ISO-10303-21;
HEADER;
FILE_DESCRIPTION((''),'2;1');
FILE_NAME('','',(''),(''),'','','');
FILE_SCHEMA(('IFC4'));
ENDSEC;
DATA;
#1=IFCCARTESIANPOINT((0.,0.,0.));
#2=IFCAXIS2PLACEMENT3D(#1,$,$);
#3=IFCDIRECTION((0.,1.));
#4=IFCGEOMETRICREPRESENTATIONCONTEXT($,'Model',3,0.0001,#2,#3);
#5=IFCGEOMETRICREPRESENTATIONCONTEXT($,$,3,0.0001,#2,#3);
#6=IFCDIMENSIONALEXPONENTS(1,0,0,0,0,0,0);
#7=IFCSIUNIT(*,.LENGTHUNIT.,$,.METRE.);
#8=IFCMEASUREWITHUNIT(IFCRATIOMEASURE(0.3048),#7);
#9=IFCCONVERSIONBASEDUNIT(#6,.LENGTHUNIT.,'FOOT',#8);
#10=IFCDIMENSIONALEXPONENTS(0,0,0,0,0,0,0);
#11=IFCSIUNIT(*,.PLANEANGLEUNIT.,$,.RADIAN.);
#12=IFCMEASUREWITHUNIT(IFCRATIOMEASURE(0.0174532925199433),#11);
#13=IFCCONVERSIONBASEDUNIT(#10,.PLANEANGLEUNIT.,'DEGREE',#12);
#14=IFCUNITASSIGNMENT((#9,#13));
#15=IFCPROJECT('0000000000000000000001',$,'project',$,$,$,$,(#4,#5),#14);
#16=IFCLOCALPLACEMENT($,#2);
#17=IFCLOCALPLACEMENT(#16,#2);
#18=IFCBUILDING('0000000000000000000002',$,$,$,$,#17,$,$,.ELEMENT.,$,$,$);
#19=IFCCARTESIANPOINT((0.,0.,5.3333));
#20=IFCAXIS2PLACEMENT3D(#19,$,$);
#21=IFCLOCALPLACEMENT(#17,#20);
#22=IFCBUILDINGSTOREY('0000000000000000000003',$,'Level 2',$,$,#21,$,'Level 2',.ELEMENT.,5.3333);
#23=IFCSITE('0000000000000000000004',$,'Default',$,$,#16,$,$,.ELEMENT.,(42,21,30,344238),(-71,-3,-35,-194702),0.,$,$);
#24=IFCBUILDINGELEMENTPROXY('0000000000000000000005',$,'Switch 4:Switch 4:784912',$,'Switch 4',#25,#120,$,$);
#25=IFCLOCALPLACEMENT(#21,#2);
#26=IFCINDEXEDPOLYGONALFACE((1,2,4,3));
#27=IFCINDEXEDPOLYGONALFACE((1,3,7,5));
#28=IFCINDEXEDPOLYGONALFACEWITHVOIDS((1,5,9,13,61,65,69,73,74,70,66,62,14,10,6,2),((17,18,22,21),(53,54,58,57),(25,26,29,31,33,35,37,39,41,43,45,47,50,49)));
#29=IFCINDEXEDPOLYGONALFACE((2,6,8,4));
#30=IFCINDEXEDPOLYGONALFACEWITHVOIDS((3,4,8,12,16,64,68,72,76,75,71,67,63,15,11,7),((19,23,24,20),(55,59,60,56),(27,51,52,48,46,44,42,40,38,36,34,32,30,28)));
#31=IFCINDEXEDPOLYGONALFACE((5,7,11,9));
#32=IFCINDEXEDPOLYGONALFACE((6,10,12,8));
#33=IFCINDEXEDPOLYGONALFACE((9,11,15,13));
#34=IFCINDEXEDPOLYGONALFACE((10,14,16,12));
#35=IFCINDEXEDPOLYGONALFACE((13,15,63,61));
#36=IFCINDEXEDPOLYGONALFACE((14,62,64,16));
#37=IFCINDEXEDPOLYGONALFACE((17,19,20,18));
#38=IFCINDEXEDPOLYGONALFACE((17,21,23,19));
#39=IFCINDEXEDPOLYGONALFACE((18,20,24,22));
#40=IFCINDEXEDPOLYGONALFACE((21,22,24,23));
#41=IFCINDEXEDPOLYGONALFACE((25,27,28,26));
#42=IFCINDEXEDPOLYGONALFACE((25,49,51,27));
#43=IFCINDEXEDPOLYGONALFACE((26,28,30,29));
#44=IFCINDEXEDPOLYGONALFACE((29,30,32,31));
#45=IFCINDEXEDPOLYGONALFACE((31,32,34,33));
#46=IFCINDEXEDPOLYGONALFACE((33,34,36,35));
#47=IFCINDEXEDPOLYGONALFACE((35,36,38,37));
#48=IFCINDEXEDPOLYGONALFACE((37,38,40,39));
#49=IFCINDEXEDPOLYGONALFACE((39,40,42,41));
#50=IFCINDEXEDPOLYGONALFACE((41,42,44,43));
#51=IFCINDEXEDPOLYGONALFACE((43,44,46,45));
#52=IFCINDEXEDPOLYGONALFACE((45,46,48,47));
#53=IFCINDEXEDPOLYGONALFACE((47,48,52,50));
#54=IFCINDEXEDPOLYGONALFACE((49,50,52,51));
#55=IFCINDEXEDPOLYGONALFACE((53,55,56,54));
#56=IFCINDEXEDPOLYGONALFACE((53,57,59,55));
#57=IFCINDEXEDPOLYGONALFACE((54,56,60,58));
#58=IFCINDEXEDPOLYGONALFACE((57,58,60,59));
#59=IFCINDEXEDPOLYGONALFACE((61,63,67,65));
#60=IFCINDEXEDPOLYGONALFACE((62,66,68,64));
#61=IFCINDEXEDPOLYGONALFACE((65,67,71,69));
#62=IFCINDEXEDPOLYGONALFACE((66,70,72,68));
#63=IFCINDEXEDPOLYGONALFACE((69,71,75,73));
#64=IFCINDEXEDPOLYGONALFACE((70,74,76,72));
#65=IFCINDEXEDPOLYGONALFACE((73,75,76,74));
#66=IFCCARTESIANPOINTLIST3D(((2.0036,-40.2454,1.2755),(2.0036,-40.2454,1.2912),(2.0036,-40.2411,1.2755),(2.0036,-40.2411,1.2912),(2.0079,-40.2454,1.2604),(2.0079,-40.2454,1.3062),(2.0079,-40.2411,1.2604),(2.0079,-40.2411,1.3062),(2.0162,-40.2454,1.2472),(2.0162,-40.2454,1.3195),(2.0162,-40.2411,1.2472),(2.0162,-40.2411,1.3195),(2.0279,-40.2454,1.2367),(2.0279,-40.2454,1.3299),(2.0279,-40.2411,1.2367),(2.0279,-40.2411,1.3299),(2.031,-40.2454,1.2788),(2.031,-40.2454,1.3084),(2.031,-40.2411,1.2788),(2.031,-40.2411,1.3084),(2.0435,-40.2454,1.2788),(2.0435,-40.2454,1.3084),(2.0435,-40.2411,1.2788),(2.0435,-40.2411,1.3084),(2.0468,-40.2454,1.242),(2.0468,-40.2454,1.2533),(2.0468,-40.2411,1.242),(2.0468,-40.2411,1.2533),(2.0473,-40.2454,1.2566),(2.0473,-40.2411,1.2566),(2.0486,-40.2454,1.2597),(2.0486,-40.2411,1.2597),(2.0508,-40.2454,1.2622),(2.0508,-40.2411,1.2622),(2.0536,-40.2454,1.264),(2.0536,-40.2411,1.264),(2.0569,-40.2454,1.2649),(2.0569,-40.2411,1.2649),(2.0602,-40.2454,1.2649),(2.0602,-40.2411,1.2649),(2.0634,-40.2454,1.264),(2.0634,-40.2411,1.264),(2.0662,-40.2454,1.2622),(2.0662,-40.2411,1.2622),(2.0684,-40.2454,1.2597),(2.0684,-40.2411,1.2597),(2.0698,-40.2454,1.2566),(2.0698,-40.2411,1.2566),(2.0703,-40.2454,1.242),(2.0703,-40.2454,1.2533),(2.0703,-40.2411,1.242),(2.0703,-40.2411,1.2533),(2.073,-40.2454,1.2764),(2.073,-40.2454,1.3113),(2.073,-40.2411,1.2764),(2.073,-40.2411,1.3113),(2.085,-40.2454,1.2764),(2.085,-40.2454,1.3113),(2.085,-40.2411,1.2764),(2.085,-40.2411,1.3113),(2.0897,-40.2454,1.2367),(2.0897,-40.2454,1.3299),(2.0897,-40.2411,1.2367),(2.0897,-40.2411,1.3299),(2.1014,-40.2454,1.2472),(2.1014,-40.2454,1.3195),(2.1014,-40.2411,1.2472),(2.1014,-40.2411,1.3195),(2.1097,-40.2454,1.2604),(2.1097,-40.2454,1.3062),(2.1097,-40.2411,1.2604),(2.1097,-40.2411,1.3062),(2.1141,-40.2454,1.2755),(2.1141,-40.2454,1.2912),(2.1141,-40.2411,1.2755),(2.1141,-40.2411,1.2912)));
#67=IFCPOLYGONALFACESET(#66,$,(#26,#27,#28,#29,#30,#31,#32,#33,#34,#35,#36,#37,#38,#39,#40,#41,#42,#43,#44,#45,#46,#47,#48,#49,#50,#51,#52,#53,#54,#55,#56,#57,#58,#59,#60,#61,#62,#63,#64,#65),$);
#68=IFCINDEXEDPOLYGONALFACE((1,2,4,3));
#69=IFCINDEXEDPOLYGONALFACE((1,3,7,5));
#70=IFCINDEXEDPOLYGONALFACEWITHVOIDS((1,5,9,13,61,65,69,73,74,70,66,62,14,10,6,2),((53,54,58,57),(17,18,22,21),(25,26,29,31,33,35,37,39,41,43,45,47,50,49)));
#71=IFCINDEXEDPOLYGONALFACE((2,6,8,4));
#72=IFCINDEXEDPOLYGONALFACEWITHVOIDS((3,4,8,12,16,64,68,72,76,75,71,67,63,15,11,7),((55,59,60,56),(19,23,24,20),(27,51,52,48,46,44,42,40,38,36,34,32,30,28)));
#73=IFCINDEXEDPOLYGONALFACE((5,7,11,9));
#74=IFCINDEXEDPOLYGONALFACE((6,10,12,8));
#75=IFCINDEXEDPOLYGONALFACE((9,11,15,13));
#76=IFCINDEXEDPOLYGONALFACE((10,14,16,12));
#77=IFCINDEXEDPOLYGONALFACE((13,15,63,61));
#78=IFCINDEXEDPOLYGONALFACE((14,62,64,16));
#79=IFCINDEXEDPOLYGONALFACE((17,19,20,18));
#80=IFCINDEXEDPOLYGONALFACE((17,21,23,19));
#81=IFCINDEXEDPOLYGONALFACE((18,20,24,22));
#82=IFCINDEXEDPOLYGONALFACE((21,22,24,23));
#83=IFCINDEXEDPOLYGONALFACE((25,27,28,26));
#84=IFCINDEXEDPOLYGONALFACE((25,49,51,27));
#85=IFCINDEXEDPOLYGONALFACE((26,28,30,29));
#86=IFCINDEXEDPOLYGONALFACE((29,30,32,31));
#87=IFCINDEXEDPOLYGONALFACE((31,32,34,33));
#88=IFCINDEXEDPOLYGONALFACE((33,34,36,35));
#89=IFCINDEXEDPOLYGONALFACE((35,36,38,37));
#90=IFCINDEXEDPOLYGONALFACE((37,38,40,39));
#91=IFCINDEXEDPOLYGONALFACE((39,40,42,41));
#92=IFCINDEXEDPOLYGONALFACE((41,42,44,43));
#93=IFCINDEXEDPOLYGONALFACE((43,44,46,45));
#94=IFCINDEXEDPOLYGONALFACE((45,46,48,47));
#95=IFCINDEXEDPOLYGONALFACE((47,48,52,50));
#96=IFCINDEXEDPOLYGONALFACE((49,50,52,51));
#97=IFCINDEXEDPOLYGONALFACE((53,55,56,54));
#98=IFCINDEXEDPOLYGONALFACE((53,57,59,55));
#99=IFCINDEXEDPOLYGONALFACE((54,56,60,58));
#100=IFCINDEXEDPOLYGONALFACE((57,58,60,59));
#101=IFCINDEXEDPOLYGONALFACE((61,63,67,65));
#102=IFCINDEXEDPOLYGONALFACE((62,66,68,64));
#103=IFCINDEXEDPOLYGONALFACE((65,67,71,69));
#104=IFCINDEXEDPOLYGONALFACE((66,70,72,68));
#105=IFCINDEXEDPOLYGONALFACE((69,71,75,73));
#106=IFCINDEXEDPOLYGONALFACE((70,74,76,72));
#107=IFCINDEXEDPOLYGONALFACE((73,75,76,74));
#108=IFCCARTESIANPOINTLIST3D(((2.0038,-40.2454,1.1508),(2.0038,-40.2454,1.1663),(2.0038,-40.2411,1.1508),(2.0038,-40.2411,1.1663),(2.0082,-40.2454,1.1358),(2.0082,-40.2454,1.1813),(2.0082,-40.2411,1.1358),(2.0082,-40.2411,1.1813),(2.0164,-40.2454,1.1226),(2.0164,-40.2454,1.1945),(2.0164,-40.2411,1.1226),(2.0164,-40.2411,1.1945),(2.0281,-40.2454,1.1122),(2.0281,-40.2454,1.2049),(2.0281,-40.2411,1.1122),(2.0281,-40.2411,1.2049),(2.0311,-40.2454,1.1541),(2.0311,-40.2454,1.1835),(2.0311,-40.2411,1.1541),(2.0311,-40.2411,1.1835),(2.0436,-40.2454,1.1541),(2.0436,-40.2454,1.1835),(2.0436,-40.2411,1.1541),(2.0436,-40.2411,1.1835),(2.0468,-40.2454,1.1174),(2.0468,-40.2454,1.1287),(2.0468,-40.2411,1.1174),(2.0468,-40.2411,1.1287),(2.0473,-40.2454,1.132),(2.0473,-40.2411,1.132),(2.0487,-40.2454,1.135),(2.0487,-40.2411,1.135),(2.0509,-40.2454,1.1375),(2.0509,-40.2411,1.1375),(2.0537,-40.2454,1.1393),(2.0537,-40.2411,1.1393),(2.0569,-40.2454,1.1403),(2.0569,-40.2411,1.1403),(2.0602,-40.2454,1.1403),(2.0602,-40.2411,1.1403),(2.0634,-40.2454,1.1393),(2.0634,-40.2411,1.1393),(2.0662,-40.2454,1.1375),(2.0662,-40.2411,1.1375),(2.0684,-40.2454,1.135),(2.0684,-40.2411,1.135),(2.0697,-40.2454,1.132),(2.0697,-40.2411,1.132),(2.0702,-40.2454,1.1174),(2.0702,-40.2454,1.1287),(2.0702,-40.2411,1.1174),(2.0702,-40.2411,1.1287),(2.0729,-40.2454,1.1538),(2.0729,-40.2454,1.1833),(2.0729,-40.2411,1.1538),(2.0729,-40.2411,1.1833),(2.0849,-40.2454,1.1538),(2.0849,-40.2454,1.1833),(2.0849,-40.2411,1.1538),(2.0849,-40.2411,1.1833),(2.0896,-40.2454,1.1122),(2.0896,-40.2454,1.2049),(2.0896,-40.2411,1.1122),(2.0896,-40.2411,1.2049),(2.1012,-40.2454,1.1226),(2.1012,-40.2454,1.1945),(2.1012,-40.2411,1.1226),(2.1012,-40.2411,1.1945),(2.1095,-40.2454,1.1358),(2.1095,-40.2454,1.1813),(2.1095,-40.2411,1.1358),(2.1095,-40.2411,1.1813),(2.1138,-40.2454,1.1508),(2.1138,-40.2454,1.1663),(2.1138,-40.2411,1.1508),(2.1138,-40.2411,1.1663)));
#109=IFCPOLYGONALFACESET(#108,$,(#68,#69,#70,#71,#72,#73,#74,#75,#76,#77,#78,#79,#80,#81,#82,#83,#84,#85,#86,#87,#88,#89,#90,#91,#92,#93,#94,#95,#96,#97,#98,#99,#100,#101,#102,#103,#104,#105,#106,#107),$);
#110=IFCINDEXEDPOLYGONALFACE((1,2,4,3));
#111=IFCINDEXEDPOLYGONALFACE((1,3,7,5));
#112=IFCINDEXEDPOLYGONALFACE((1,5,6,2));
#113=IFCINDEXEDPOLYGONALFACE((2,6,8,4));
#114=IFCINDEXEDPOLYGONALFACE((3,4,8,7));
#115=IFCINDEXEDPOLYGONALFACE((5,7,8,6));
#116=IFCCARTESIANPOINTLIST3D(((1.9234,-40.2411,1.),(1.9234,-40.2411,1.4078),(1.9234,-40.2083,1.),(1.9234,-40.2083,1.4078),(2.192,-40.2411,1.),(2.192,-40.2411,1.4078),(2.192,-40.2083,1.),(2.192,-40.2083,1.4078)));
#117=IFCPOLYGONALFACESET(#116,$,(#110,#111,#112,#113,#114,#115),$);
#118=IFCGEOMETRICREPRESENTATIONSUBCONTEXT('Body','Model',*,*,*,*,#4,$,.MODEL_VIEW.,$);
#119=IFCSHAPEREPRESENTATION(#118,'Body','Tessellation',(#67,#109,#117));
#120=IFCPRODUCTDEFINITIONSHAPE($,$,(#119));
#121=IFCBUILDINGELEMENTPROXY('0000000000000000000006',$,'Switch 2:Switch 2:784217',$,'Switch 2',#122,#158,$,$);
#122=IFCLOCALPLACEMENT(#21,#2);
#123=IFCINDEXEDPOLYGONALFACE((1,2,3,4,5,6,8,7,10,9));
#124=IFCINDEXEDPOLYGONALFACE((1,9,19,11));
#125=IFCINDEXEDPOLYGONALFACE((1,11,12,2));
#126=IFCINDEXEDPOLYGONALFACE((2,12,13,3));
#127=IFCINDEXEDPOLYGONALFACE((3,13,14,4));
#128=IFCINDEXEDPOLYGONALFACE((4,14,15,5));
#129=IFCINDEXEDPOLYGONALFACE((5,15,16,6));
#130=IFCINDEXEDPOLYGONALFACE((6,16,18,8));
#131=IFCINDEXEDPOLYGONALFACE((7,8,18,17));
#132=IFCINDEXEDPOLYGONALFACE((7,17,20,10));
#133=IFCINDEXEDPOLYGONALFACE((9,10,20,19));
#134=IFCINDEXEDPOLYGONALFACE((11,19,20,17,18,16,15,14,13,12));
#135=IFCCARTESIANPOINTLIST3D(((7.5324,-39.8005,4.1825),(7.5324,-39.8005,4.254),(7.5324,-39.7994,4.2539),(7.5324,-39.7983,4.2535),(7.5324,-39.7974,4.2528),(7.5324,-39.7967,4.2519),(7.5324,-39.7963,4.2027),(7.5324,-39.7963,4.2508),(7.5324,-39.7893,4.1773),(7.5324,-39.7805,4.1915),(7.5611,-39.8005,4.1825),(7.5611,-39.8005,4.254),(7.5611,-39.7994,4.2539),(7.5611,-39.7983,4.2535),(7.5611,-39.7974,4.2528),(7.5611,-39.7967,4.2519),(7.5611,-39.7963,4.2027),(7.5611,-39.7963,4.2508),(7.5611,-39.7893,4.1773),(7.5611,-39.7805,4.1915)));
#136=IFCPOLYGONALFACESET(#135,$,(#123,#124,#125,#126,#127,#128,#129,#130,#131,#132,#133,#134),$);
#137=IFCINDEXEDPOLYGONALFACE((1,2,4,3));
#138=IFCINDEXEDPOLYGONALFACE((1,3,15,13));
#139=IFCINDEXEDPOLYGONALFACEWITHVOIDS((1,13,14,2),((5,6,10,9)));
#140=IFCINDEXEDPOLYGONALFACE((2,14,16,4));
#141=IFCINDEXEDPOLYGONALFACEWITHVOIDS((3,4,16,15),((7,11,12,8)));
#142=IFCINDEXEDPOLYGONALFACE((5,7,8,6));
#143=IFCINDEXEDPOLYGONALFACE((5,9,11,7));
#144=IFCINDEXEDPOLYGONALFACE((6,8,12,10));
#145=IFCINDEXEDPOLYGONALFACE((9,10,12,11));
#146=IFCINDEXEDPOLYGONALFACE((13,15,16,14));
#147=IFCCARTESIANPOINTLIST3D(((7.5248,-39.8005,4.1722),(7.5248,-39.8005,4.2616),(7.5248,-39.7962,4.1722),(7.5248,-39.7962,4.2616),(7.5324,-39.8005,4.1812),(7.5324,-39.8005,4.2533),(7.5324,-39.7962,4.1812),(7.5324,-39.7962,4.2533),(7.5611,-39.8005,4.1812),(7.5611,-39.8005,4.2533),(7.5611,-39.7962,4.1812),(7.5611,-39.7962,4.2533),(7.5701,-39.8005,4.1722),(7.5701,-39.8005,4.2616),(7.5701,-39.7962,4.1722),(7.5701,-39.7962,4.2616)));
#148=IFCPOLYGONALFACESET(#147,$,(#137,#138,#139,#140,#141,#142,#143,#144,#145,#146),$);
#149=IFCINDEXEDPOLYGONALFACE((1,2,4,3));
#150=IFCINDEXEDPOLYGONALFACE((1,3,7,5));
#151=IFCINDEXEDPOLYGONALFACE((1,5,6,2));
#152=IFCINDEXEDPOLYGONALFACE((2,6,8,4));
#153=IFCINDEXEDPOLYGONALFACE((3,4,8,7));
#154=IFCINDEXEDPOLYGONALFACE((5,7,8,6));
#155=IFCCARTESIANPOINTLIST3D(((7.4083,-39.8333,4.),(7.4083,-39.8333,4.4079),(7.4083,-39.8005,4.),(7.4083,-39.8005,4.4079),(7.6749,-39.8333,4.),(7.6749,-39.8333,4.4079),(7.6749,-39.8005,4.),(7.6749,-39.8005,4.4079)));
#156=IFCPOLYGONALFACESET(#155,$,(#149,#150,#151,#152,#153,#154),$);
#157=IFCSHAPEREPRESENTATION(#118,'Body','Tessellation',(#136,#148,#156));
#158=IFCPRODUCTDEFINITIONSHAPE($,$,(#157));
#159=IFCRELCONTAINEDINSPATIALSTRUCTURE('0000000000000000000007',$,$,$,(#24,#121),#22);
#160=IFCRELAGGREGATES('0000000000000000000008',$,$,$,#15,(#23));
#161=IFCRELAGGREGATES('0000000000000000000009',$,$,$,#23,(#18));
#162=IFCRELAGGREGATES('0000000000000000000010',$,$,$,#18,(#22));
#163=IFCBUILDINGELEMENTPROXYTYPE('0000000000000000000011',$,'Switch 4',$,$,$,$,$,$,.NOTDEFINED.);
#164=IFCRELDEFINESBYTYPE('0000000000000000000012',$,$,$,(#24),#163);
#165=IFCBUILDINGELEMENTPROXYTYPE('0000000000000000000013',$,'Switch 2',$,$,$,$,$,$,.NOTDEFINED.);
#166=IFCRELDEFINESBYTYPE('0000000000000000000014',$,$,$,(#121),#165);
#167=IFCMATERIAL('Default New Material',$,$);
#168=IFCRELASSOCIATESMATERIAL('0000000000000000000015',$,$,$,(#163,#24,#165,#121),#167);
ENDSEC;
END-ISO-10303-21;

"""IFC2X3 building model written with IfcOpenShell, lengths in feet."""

from ifc_helpers import new_model, entity, si_unit, converted_unit, direction, frame, frame_2d, origin, origin_2d_with_axis, place, context, subcontext, project, spatial, polyline, circle_curve, parameter, trimmed, segment, composite_curve, rectangle, outline, extrude, source, transform, mapped, material, type_object, type_shapes, element, save


model = new_model("IFC2X3")

# Units and contexts
model_context = context("Model", 3, precision=0.0001, world=origin(), true_north=direction((0.0, 1.0)))
context_of_model = context(None, 3, precision=0.0001, world=origin(), true_north=direction((0.0, 1.0)))
body_context = subcontext(model_context, "Body", "Model", "MODEL_VIEW")
ifc_project = project(units=[converted_unit("LENGTHUNIT", "FOOT", entity("IfcRatioMeasure", 0.3048), si_unit("LENGTHUNIT", "METRE"), dimensions=[1, 0, 0, 0, 0, 0, 0]), converted_unit("PLANEANGLEUNIT", "DEGREE", entity("IfcRatioMeasure", 0.0174532925199433), si_unit("PLANEANGLEUNIT", "RADIAN"), dimensions=[0, 0, 0, 0, 0, 0, 0])], contexts=[model_context, context_of_model])

# Site, building, storey
site_placement = place(None, origin())
site = spatial("IfcSite", under=ifc_project, at=site_placement, Name="Default", CompositionType="ELEMENT", RefLatitude=(42, 21, 30, 344238), RefLongitude=(-71, -3, -35, -194702), RefElevation=0.0)
building_placement = place(site_placement, origin())
building = spatial("IfcBuilding", under=site, at=building_placement, CompositionType="ELEMENT")
storey_placement = place(building_placement, frame((0.0, 0.0, 5.3333)))
storey = spatial("IfcBuildingStorey", under=building, at=storey_placement, Name="Level 2", LongName="Level 2", CompositionType="ELEMENT", Elevation=5.3333)

# Shared definitions
ifc_material = material(Name="Default New Material")

# Building element proxies
building_element_proxy_type_1 = type_object("IfcBuildingElementProxyType", Name="Switch 4", PredefinedType="NOTDEFINED", material=ifc_material)
shared_shape_1 = source(origin(), body_context, "Body", "SweptSolid", [
    extrude(outline(composite_curve([segment(polyline([(-0.0309, -0.0466), (0.0309, -0.0466)]), True, "CONTINUOUS"), segment(trimmed(circle_curve(frame_2d((-0.0003, 0.0), x_axis=(-1.0, 0.0)), 0.0561), [parameter(123.794741)], [parameter(236.205259)], True, "PARAMETER"), True, "CONTINUOUS"), segment(polyline([(0.0309, 0.0466), (-0.0309, 0.0466)]), True, "CONTINUOUS"), segment(trimmed(circle_curve(frame_2d((0.0003, 0.0), x_axis=(1.0, 0.0)), 0.0561), [parameter(123.794741)], [parameter(236.205259)], True, "PARAMETER"), True, "CONTINUOUS")], self_intersect=False), holes=[polyline([(0.0142, 0.0279), (0.0262, 0.0279), (0.0262, -0.0069), (0.0142, -0.0069), (0.0142, 0.0279)]), polyline([(-0.0153, 0.025), (-0.0153, -0.0045), (-0.0278, -0.0045), (-0.0278, 0.025), (-0.0153, 0.025)]), composite_curve([segment(polyline([(-0.012, -0.0413), (-0.012, -0.03)]), True, "CONTINUOUS"), segment(trimmed(circle_curve(frame_2d((-0.0003, -0.03), x_axis=(-1.0, 0.0)), 0.0117), [parameter(180.0)], [parameter(0.0)], True, "PARAMETER"), False, "CONTINUOUS"), segment(polyline([(0.0115, -0.03), (0.0115, -0.0413)]), True, "CONTINUOUS"), segment(polyline([(0.0115, -0.0413), (-0.012, -0.0413)]), True, "CONTINUOUS")], self_intersect=False)]), frame((-0.0011, 0.0328, 0.2833), z_axis=(0.0, 1.0, 0.0), x_axis=(-1.0, 0.0, 0.0)), (0.0, 0.0, 1.0), 0.0042),
    extrude(outline(composite_curve([segment(polyline([(-0.0308, -0.0464), (0.0308, -0.0464)]), True, "CONTINUOUS"), segment(trimmed(circle_curve(frame_2d((-0.0003, 0.0), x_axis=(-1.0, 0.0)), 0.0558), [parameter(123.794741)], [parameter(236.205259)], True, "PARAMETER"), True, "CONTINUOUS"), segment(polyline([(0.0308, 0.0464), (-0.0308, 0.0464)]), True, "CONTINUOUS"), segment(trimmed(circle_curve(frame_2d((0.0003, 0.0), x_axis=(1.0, 0.0)), 0.0558), [parameter(123.794741)], [parameter(236.205259)], True, "PARAMETER"), True, "CONTINUOUS")], self_intersect=False), holes=[polyline([(0.0141, 0.0247), (0.026, 0.0247), (0.026, -0.0047), (0.0141, -0.0047), (0.0141, 0.0247)]), polyline([(-0.0152, 0.0249), (-0.0152, -0.0045), (-0.0277, -0.0045), (-0.0277, 0.0249), (-0.0152, 0.0249)]), composite_curve([segment(polyline([(-0.012, -0.0411), (-0.012, -0.0299)]), True, "CONTINUOUS"), segment(trimmed(circle_curve(frame_2d((-0.0003, -0.0299), x_axis=(-1.0, 0.0)), 0.0117), [parameter(180.0)], [parameter(0.0)], True, "PARAMETER"), False, "CONTINUOUS"), segment(polyline([(0.0114, -0.0299), (0.0114, -0.0411)]), True, "CONTINUOUS"), segment(polyline([(0.0114, -0.0411), (-0.012, -0.0411)]), True, "CONTINUOUS")], self_intersect=False)]), frame((-0.0011, 0.0328, 0.1586), z_axis=(0.0, 1.0, 0.0), x_axis=(-1.0, 0.0, 0.0)), (0.0, 0.0, 1.0), 0.0042),
    extrude(rectangle(XDim=0.0328, YDim=0.2687, at=origin_2d_with_axis()), frame((0.0, 0.0164, 0.0), z_axis=(0.0, 0.0, 1.0), x_axis=(0.0, -1.0, 0.0)), (0.0, 0.0, 1.0), 0.4078),
])
type_shapes(building_element_proxy_type_1, [shared_shape_1])
proxy_1_placement = place(storey_placement, frame((2.0577, -40.2083, 1.0), z_axis=(0.0, 0.0, 1.0), x_axis=(-1.0, 0.0, 0.0)))
element("IfcBuildingElementProxy", 1, at=proxy_1_placement, inside=storey, type_object=building_element_proxy_type_1, material=ifc_material, Name="Switch 4:Switch 4:784912", ObjectType="Switch 4", context=body_context, shape_type="MappedRepresentation", body=[
    mapped(shared_shape_1, transform((0.0, 0.0, 0.0), scale=1.0)),
])
building_element_proxy_type_2 = type_object("IfcBuildingElementProxyType", Name="Switch 2", PredefinedType="NOTDEFINED", material=ifc_material)
shared_shape_2 = source(origin(), body_context, "Body", "SweptSolid", [
    extrude(outline(composite_curve([segment(polyline([(-0.0252, -0.0211), (-0.0084, -0.0211)]), True, "CONTINUOUS"), segment(polyline([(-0.0084, -0.0211), (-0.0073, -0.0017)]), True, "CONTINUOUS"), segment(polyline([(-0.0073, -0.0017), (0.0336, 0.0237)]), True, "CONTINUOUS"), segment(trimmed(circle_curve(frame_2d((0.0308, 0.0266), x_axis=(0.848706, 0.528865)), 0.004), [parameter(281.689503)], [parameter(4.471238)], True, "PARAMETER"), True, "CONTINUOUS"), segment(polyline([(0.034, 0.029), (-0.0267, -0.0088)]), True, "CONTINUOUS"), segment(polyline([(-0.0267, -0.0088), (-0.0252, -0.0211)]), True, "CONTINUOUS")], self_intersect=False)), frame((-0.0093, 0.0394, 0.2098), z_axis=(1.0, 0.0, 0.0), x_axis=(0.0, 0.528865, 0.848706)), (0.0, 0.0, 1.0), 0.0287),
    extrude(outline(polyline([(-0.0447, -0.0227), (0.0447, -0.0227), (0.0447, 0.0227), (-0.0447, 0.0227), (-0.0447, -0.0227)]), holes=[polyline([(-0.0364, -0.0136), (-0.0364, 0.0151), (0.0357, 0.0151), (0.0357, -0.0136), (-0.0364, -0.0136)])]), frame((0.0058, 0.0329, 0.2169), z_axis=(0.0, 1.0, 0.0), x_axis=(0.0, 0.0, -1.0)), (0.0, 0.0, 1.0), 0.0042),
    extrude(rectangle(XDim=0.0329, YDim=0.2666, at=origin_2d_with_axis()), frame((-0.0001, 0.0164, 0.0), z_axis=(0.0, 0.0, 1.0), x_axis=(0.0, -1.0, 0.0)), (0.0, 0.0, 1.0), 0.4079),
])
type_shapes(building_element_proxy_type_2, [shared_shape_2])
proxy_2_placement = place(storey_placement, frame((7.5417, -39.8333, 4.0)))
element("IfcBuildingElementProxy", 2, at=proxy_2_placement, inside=storey, type_object=building_element_proxy_type_2, material=ifc_material, Name="Switch 2:Switch 2:784217", ObjectType="Switch 2", context=body_context, shape_type="MappedRepresentation", body=[
    mapped(shared_shape_2, transform((0.0, 0.0, 0.0), scale=1.0)),
])

save(model, "model.ifc")
